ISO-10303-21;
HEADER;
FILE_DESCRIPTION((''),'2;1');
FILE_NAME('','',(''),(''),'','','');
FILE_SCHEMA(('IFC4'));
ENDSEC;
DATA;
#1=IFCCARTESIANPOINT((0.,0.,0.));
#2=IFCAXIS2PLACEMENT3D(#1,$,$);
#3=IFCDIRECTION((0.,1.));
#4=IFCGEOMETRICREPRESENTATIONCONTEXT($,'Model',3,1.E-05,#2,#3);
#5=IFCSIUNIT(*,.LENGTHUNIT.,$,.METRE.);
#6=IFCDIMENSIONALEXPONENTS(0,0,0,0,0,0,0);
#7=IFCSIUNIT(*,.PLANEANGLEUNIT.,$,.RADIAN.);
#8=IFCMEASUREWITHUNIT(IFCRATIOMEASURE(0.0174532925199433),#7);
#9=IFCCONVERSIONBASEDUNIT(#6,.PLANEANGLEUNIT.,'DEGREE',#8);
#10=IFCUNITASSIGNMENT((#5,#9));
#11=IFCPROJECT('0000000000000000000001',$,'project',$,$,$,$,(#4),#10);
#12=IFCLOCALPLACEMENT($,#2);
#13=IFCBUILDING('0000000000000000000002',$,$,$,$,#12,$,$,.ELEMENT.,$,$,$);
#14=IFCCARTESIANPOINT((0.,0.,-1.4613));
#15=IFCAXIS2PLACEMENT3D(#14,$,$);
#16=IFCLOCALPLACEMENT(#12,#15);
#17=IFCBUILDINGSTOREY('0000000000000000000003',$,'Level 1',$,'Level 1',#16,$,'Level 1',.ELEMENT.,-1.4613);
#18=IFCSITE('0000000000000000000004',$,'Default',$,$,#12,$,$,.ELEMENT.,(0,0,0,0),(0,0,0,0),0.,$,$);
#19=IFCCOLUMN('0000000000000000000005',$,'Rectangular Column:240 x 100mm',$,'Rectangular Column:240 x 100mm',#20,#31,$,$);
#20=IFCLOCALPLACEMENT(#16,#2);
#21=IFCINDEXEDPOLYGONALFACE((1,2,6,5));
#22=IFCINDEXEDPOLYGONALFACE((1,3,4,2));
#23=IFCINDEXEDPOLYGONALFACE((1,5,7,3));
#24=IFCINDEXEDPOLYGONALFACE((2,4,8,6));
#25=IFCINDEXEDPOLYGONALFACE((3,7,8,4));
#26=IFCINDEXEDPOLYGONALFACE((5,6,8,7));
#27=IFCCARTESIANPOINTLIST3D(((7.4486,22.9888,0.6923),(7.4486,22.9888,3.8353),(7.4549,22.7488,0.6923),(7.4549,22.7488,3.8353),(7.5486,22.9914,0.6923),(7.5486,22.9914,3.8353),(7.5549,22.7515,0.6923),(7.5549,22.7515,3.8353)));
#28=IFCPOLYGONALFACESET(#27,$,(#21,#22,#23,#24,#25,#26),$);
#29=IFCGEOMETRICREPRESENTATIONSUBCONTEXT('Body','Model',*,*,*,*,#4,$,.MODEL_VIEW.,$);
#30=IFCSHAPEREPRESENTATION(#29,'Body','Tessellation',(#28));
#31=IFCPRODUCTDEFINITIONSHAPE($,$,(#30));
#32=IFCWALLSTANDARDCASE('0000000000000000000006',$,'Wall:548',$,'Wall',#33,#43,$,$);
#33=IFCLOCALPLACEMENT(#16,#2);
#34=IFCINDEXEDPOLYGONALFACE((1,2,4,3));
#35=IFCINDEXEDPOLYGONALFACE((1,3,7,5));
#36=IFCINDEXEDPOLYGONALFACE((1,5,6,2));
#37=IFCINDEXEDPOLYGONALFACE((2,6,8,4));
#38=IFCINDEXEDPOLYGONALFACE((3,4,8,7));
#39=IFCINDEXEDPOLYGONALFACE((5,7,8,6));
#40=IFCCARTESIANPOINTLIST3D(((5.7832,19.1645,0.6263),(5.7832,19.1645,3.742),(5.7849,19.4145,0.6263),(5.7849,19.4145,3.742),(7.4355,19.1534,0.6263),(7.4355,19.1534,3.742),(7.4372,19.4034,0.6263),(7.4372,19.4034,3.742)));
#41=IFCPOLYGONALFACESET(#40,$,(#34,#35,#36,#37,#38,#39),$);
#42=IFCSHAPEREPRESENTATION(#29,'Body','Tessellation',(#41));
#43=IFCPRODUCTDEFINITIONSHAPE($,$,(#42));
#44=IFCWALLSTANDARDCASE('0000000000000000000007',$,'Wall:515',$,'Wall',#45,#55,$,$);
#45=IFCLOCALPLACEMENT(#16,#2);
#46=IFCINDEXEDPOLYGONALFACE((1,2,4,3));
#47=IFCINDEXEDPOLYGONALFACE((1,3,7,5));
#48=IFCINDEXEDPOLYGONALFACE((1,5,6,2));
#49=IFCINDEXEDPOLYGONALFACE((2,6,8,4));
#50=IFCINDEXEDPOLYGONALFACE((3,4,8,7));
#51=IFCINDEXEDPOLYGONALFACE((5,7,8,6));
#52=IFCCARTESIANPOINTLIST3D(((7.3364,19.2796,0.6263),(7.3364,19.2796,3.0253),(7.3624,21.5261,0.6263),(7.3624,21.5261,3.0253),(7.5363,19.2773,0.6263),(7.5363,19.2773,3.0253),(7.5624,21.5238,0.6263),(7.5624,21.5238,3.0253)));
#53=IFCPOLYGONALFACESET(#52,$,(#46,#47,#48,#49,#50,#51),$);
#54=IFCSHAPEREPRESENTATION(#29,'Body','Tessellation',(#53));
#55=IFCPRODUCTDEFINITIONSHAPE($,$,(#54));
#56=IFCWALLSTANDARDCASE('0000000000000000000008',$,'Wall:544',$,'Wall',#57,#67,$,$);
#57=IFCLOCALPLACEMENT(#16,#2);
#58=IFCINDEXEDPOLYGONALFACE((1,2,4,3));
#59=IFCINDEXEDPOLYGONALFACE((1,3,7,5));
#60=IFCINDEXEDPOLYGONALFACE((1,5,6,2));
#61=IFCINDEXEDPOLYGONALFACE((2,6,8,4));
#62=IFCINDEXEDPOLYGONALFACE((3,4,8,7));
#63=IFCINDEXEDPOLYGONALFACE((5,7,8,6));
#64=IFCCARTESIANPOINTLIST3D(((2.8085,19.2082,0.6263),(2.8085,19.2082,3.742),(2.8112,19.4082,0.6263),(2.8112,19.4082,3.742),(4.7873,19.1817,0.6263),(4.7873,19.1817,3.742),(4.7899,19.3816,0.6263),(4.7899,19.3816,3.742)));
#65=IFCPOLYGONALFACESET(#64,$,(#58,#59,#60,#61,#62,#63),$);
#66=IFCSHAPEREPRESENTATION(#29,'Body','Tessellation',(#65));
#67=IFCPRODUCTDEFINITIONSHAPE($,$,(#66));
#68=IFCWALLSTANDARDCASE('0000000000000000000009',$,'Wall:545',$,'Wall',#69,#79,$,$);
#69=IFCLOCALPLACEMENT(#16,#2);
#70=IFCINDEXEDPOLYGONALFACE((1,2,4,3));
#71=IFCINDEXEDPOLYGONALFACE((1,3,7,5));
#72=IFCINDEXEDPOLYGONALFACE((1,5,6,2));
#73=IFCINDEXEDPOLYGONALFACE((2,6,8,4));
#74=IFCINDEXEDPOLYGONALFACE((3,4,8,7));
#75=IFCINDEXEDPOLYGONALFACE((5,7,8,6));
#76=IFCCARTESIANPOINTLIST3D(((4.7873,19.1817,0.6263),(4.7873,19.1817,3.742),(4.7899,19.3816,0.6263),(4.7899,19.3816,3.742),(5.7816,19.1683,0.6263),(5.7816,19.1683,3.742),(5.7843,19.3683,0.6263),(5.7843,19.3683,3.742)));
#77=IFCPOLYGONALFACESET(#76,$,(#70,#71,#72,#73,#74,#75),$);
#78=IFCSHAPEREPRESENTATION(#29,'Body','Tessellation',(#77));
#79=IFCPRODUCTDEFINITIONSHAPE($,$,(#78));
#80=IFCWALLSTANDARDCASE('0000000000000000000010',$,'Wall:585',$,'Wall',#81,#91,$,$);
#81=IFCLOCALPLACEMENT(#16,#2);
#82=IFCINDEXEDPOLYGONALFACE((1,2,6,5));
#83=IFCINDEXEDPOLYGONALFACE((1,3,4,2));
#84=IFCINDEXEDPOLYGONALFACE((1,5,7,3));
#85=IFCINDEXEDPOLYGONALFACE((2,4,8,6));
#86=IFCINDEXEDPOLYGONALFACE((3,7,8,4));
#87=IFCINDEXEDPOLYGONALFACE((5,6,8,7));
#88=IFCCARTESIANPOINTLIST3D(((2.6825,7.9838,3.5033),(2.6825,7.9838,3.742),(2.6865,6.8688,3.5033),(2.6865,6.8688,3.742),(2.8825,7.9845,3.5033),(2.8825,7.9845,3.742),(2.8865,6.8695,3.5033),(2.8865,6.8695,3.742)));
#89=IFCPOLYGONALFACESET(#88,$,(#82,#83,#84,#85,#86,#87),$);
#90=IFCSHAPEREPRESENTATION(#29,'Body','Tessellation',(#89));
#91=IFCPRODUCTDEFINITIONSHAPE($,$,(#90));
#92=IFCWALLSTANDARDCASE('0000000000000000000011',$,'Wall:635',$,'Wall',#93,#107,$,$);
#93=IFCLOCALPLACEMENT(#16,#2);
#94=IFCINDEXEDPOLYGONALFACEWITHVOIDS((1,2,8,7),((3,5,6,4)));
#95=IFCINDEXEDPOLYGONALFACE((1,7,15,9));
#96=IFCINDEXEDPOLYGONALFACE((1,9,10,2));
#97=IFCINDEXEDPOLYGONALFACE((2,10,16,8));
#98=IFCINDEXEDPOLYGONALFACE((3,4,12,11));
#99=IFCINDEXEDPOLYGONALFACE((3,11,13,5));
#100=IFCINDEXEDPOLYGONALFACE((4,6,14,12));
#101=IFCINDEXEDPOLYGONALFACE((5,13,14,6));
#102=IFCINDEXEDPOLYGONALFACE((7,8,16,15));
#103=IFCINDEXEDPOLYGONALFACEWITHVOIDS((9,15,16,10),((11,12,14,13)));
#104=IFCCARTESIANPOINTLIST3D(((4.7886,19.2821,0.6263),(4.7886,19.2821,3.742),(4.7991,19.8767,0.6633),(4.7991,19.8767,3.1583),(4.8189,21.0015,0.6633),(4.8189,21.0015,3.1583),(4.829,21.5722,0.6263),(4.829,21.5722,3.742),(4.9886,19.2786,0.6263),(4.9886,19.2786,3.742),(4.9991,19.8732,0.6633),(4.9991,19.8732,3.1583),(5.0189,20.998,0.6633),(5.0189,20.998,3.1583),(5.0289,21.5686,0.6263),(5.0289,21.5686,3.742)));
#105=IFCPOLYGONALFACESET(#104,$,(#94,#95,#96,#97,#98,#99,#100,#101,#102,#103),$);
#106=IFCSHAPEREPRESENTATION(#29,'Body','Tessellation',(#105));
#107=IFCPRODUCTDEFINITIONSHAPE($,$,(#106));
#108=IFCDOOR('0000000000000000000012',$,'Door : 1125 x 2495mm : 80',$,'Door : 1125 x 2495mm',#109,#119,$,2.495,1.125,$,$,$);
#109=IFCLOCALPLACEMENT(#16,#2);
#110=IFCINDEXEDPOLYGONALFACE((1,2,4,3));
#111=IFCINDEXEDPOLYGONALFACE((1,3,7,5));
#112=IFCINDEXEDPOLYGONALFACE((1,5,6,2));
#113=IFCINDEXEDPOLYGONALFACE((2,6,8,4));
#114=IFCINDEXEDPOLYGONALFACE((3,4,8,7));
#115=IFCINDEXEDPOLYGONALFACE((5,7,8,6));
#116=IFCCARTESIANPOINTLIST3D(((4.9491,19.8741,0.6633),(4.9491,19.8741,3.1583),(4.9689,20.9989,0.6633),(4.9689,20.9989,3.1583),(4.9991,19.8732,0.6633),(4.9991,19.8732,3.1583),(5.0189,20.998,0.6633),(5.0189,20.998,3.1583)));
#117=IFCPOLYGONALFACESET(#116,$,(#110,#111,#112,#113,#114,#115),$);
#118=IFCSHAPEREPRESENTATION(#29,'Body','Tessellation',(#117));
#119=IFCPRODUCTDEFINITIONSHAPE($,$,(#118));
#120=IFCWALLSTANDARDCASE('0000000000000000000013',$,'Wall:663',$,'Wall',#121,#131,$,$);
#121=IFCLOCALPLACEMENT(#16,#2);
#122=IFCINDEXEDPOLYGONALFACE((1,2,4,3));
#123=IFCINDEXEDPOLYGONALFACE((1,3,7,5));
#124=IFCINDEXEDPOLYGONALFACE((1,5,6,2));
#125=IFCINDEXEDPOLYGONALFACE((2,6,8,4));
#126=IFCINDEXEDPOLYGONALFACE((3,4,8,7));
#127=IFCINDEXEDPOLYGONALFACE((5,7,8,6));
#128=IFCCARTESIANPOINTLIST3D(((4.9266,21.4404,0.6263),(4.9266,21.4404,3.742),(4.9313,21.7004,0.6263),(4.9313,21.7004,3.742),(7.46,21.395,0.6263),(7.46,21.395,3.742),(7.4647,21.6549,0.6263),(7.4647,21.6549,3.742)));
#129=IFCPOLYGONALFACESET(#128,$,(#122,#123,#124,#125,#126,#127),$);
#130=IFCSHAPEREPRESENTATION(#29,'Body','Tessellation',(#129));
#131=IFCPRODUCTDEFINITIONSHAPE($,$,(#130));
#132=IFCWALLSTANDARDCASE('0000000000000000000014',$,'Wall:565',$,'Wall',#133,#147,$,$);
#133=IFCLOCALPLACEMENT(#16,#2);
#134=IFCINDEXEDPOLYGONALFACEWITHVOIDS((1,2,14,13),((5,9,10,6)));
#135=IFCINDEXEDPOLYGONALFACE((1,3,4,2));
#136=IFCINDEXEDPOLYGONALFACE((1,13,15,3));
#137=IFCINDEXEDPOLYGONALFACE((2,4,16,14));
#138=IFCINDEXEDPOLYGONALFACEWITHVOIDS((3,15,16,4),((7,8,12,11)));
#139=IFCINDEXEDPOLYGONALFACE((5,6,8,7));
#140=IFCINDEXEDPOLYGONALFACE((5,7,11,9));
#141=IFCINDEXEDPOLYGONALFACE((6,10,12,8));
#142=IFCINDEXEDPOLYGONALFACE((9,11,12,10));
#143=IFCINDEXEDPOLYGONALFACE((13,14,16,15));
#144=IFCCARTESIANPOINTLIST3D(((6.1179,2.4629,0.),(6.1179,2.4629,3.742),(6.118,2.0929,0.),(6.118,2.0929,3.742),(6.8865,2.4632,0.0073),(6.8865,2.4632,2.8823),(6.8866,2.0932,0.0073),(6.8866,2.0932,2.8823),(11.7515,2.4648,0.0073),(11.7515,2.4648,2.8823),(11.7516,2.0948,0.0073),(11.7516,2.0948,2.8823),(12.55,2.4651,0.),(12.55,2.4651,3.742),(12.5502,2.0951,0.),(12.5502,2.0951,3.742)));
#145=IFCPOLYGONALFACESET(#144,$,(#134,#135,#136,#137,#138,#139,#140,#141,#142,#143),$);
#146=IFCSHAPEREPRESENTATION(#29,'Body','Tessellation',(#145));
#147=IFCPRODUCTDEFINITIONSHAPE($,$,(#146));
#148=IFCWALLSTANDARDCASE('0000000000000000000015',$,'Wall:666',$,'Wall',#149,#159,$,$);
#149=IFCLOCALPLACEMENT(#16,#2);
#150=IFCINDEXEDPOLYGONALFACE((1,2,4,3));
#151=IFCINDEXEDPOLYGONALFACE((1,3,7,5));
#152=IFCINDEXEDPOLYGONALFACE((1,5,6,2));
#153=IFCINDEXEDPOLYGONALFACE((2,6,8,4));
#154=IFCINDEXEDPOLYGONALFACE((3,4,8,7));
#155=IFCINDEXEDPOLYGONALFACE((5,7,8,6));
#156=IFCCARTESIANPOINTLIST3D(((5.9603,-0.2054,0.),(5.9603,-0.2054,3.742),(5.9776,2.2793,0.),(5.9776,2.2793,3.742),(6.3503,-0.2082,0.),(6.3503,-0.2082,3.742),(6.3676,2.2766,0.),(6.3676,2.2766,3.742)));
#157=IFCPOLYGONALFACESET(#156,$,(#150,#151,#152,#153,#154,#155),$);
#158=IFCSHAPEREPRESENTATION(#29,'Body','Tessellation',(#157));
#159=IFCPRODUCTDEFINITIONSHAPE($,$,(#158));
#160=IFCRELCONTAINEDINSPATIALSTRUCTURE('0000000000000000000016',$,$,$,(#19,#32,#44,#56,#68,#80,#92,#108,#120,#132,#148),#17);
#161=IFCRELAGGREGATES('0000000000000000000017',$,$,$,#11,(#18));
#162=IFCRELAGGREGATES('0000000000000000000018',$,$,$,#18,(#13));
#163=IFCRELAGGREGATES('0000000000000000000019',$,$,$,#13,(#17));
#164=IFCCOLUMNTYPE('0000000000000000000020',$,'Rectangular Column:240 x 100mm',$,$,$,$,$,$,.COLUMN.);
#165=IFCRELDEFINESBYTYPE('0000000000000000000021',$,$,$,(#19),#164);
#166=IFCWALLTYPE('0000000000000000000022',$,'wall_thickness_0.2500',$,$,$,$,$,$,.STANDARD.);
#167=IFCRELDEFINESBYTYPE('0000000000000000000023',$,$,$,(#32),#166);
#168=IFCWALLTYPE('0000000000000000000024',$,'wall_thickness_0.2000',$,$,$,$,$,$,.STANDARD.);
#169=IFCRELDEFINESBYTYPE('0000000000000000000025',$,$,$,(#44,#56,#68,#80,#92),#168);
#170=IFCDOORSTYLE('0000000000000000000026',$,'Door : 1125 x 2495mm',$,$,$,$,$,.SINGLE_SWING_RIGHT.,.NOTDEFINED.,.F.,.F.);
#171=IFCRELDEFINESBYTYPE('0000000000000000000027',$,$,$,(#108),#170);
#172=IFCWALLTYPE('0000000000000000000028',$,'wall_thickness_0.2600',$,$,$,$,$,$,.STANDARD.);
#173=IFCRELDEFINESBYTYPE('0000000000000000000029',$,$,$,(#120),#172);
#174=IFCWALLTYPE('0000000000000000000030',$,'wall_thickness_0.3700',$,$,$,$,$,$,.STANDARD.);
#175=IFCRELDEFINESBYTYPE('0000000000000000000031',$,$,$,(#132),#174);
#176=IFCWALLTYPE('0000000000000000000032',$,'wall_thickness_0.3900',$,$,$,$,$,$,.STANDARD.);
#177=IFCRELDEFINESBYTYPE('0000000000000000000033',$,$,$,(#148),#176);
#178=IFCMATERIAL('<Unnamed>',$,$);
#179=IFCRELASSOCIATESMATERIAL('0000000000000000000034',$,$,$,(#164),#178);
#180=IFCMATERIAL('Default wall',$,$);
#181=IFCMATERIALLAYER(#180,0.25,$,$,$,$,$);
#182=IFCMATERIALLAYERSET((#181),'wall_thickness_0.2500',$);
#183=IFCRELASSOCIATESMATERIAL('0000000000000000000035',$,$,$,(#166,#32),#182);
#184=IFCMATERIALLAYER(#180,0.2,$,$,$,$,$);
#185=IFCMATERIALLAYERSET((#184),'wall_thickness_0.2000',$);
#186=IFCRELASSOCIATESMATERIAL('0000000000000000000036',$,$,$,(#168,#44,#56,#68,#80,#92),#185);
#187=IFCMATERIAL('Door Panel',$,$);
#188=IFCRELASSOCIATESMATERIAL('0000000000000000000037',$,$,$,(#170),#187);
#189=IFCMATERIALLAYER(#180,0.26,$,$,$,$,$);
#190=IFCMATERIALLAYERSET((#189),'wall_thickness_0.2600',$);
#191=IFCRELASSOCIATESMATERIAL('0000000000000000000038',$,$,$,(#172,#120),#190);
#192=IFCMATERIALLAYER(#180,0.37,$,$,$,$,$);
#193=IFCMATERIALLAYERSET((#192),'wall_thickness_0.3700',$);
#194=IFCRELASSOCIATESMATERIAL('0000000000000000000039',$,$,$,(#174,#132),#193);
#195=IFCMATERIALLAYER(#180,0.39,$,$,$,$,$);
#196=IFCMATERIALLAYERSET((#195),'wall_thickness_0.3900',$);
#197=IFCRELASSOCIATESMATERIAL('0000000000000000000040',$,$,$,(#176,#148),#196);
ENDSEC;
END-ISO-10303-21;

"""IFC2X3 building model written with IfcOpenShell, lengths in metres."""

from ifc_helpers import new_model, entity, si_unit, converted_unit, direction, frame, frame_2d, origin, origin_2d_with_axis, place, context, subcontext, project, spatial, polyline, rectangle, outline, extrude, source, transform, mapped, material, layer, layer_set, layer_usage, type_object, type_shapes, element, fill, save


model = new_model("IFC2X3")

# Units and contexts
model_context = context("Model", 3, precision=1e-05, world=origin(), true_north=direction((0.0, 1.0)))
body_context = subcontext(model_context, "Body", "Model", "MODEL_VIEW")
ifc_project = project(units=[si_unit("LENGTHUNIT", "METRE"), converted_unit("PLANEANGLEUNIT", "DEGREE", entity("IfcRatioMeasure", 0.0174532925199433), si_unit("PLANEANGLEUNIT", "RADIAN"), dimensions=[0, 0, 0, 0, 0, 0, 0])], contexts=[model_context])

# Site, building, storey
placement_1 = place(None, origin())
site = spatial("IfcSite", under=ifc_project, at=placement_1, Name="Default", CompositionType="ELEMENT", RefLatitude=(0, 0, 0, 0), RefLongitude=(0, 0, 0, 0), RefElevation=0.0)
building = spatial("IfcBuilding", under=site, at=placement_1, CompositionType="ELEMENT")
storey_placement = place(placement_1, frame((0.0, 0.0, -1.4613)))
storey = spatial("IfcBuildingStorey", under=building, at=storey_placement, Name="Level 1", ObjectType="Level 1", LongName="Level 1", CompositionType="ELEMENT", Elevation=-1.4613)

# Column
ifc_material_1 = material(Name="<Unnamed>")
column_type = type_object("IfcColumnType", Name="Rectangular Column:240 x 100mm", PredefinedType="COLUMN", material=ifc_material_1)
shared_shape_1 = source(origin(), body_context, "Body", "SweptSolid", [
    extrude(rectangle(XDim=0.24, YDim=0.1, at=origin_2d_with_axis()), frame((0.0, 0.0, 0.0), z_axis=(0.0, 0.0, 1.0), x_axis=(0.0, -1.0, 0.0)), (0.0, 0.0, 1.0), 3.143),
])
type_shapes(column_type, [shared_shape_1])
column_placement = place(placement_1, frame((7.5018, 22.8701, -0.769), z_axis=(0.0, 0.0, 1.0), x_axis=(0.99966, 0.026087, 0.0)))
element("IfcColumn", 1, at=column_placement, inside=storey, type_object=column_type, Name="Rectangular Column:240 x 100mm", ObjectType="Rectangular Column:240 x 100mm", context=body_context, shape_type="MappedRepresentation", body=[
    mapped(shared_shape_1, transform((0.0, 0.0, 0.0), scale=1.0)),
])

# Walls
ifc_material_2 = material(Name="Default wall")
ifc_layer_1 = layer(ifc_material_2, 0.25)
ifc_layer_set_1 = layer_set([ifc_layer_1], Name="wall_thickness_0.2500")
ifc_layer_usage_1 = layer_usage(ifc_layer_set_1, "AXIS2", "POSITIVE", -0.125)
wall_type_1 = type_object("IfcWallType", Name="wall_thickness_0.2500", PredefinedType="STANDARD", material=ifc_layer_set_1)
placement_2 = place(placement_1, frame((0.0, 0.0, -0.835)))
wall_1_placement = place(placement_2, frame((5.7841, 19.2895, 0.0), z_axis=(0.0, 0.0, 1.0), x_axis=(0.999978, -0.006702, 0.0)))
element("IfcWallStandardCase", 2, at=wall_1_placement, inside=storey, type_object=wall_type_1, material=ifc_layer_usage_1, Name="Wall:548", ObjectType="Wall", context=body_context, shape_type="SweptSolid", body=[
    extrude(outline(polyline([(1.6523, -0.125), (1.6523, 0.125), (0.0, 0.125), (0.0, -0.125), (1.6523, -0.125)])), origin(), (0.0, 0.0, 1.0), 3.1157),
])
ifc_layer_2 = layer(ifc_material_2, 0.2)
ifc_layer_set_2 = layer_set([ifc_layer_2], Name="wall_thickness_0.2000")
ifc_layer_usage_2 = layer_usage(ifc_layer_set_2, "AXIS2", "POSITIVE", -0.1)
wall_type_2 = type_object("IfcWallType", Name="wall_thickness_0.2000", PredefinedType="STANDARD", material=ifc_layer_set_2)
placement_3 = place(placement_1, frame((0.0, 0.0, -0.835)))
wall_2_placement = place(placement_3, frame((7.4624, 21.5249, 0.0), z_axis=(0.0, 0.0, 1.0), x_axis=(-0.011587, -0.999933, 0.0)))
element("IfcWallStandardCase", 3, at=wall_2_placement, inside=storey, type_object=wall_type_2, material=ifc_layer_usage_2, Name="Wall:515", ObjectType="Wall", context=body_context, shape_type="SweptSolid", body=[
    extrude(outline(polyline([(2.2467, -0.1), (2.2467, 0.1), (0.0, 0.1), (0.0, -0.1), (2.2467, -0.1)])), origin(), (0.0, 0.0, 1.0), 2.399),
])
placement_4 = place(placement_1, frame((0.0, 0.0, -0.835)))
wall_3_placement = place(placement_4, frame((2.8098, 19.3082, 0.0), z_axis=(0.0, 0.0, 1.0), x_axis=(0.99991, -0.013422, 0.0)))
element("IfcWallStandardCase", 4, at=wall_3_placement, inside=storey, type_object=wall_type_2, material=ifc_layer_usage_2, Name="Wall:544", ObjectType="Wall", context=body_context, shape_type="SweptSolid", body=[
    extrude(outline(polyline([(1.979, -0.1), (1.979, 0.1), (0.0, 0.1), (0.0, -0.1), (1.979, -0.1)])), origin(), (0.0, 0.0, 1.0), 3.1157),
])
placement_5 = place(placement_1, frame((0.0, 0.0, -0.835)))
wall_4_placement = place(placement_5, frame((4.7886, 19.2817, 0.0), z_axis=(0.0, 0.0, 1.0), x_axis=(0.99991, -0.013422, 0.0)))
element("IfcWallStandardCase", 5, at=wall_4_placement, inside=storey, type_object=wall_type_2, material=ifc_layer_usage_2, Name="Wall:545", ObjectType="Wall", context=body_context, shape_type="SweptSolid", body=[
    extrude(outline(polyline([(0.9944, -0.1), (0.9944, 0.1), (0.0, 0.1), (0.0, -0.1), (0.9944, -0.1)])), origin(), (0.0, 0.0, 1.0), 3.1157),
])
placement_6 = place(placement_1, frame((0.0, 0.0, 2.042)))
wall_5_placement = place(placement_6, frame((2.7865, 6.8691, 0.0), z_axis=(0.0, 0.0, 1.0), x_axis=(-0.003571, 0.999994, 0.0)))
element("IfcWallStandardCase", 6, at=wall_5_placement, inside=storey, type_object=wall_type_2, material=ifc_layer_usage_2, Name="Wall:585", ObjectType="Wall", context=body_context, shape_type="SweptSolid", body=[
    extrude(outline(polyline([(1.115, -0.1), (1.115, 0.1), (0.0, 0.1), (0.0, -0.1), (1.115, -0.1)])), origin(), (0.0, 0.0, 1.0), 0.2387),
])

# Wall, opening, door
placement_7 = place(placement_1, frame((0.0, 0.0, -0.835)))
wall_6_placement = place(placement_7, frame((4.9289, 21.5704, 0.0), z_axis=(0.0, 0.0, 1.0), x_axis=(-0.017619, -0.999845, 0.0)))
wall_6 = element("IfcWallStandardCase", 7, at=wall_6_placement, inside=storey, type_object=wall_type_2, material=ifc_layer_usage_2, Name="Wall:635", ObjectType="Wall", context=body_context, shape_type="SweptSolid", body=[
    extrude(outline(polyline([(2.2905, -0.1), (2.2905, 0.1), (0.0, 0.1), (0.0, -0.1), (2.2905, -0.1)])), origin(), (0.0, 0.0, 1.0), 3.1157),
])
opening_1_placement = place(wall_6_placement, frame((0.5707, -0.1, 0.037)))
opening_1 = element("IfcOpeningElement", 8, at=opening_1_placement, cuts=wall_6, ObjectType="Opening", context=body_context, shape_type="SweptSolid", body=[
    extrude(rectangle(XDim=1.125, YDim=2.495, at=frame_2d((1.2475, 0.5625), x_axis=(0.0, 1.0))), frame((0.0, 0.0, 0.0), z_axis=(0.0, 1.0, 0.0), x_axis=(0.0, 0.0, 1.0)), (0.0, 0.0, 1.0), 0.2),
])
ifc_material_3 = material(Name="Door Panel")
door_style_1 = type_object("IfcDoorStyle", Name="Door : 1125 x 2495mm", ConstructionType="NOTDEFINED", OperationType="SINGLE_SWING_RIGHT", ParameterTakesPrecedence=False, Sizeable=False, material=ifc_material_3)
shared_shape_2 = source(origin(), body_context, "Body", "SweptSolid", [
    extrude(rectangle(XDim=0.05, YDim=1.125, at=origin_2d_with_axis()), frame((0.5625, 0.175, 0.0), z_axis=(0.0, 0.0, 1.0), x_axis=(0.0, 1.0, 0.0)), (0.0, 0.0, 1.0), 2.495),
])
type_shapes(door_style_1, [shared_shape_2])
door_1_placement = place(opening_1_placement, origin())
door_1 = element("IfcDoor", 9, at=door_1_placement, inside=storey, type_object=door_style_1, Name="Door : 1125 x 2495mm : 80", ObjectType="Door : 1125 x 2495mm", OverallHeight=2.495, OverallWidth=1.125, context=body_context, shape_type="MappedRepresentation", body=[
    mapped(shared_shape_2, transform((0.0, 0.0, 0.0), scale=1.0)),
])
fill(opening_1, door_1)

# Wall
ifc_layer_3 = layer(ifc_material_2, 0.26)
ifc_layer_set_3 = layer_set([ifc_layer_3], Name="wall_thickness_0.2600")
ifc_layer_usage_3 = layer_usage(ifc_layer_set_3, "AXIS2", "POSITIVE", -0.13)
wall_type_3 = type_object("IfcWallType", Name="wall_thickness_0.2600", PredefinedType="STANDARD", material=ifc_layer_set_3)
placement_8 = place(placement_1, frame((0.0, 0.0, -0.835)))
wall_7_placement = place(placement_8, frame((4.9289, 21.5704, 0.0), z_axis=(0.0, 0.0, 1.0), x_axis=(0.999839, -0.017946, 0.0)))
element("IfcWallStandardCase", 10, at=wall_7_placement, inside=storey, type_object=wall_type_3, material=ifc_layer_usage_3, Name="Wall:663", ObjectType="Wall", context=body_context, shape_type="SweptSolid", body=[
    extrude(outline(polyline([(2.5338, -0.13), (2.5338, 0.13), (0.0, 0.13), (0.0, -0.13), (2.5338, -0.13)])), origin(), (0.0, 0.0, 1.0), 3.1157),
])

# Wall, opening
ifc_layer_4 = layer(ifc_material_2, 0.37)
ifc_layer_set_4 = layer_set([ifc_layer_4], Name="wall_thickness_0.3700")
ifc_layer_usage_4 = layer_usage(ifc_layer_set_4, "AXIS2", "POSITIVE", -0.185)
wall_type_4 = type_object("IfcWallType", Name="wall_thickness_0.3700", PredefinedType="STANDARD", material=ifc_layer_set_4)
wall_8_placement = place(storey_placement, frame((6.1179, 2.2779, 0.0), z_axis=(0.0, 0.0, 1.0), x_axis=(1.0, 0.000342, 0.0)))
wall_8 = element("IfcWallStandardCase", 11, at=wall_8_placement, inside=storey, type_object=wall_type_4, material=ifc_layer_usage_4, Name="Wall:565", ObjectType="Wall", context=body_context, shape_type="SweptSolid", body=[
    extrude(outline(polyline([(6.4322, -0.185), (6.4322, 0.185), (0.0, 0.185), (0.0, -0.185), (6.4322, -0.185)])), origin(), (0.0, 0.0, 1.0), 3.742),
])
opening_2_placement = place(wall_8_placement, frame((0.7686, -0.185, 0.0073)))
element("IfcOpeningElement", 12, at=opening_2_placement, cuts=wall_8, ObjectType="Opening", context=body_context, shape_type="SweptSolid", body=[
    extrude(rectangle(XDim=4.865, YDim=2.875, at=frame_2d((1.4375, 2.4325), x_axis=(0.0, 1.0))), frame((0.0, 0.0, 0.0), z_axis=(0.0, 1.0, 0.0), x_axis=(0.0, 0.0, 1.0)), (0.0, 0.0, 1.0), 0.37),
])

# Wall
ifc_layer_5 = layer(ifc_material_2, 0.39)
ifc_layer_set_5 = layer_set([ifc_layer_5], Name="wall_thickness_0.3900")
ifc_layer_usage_5 = layer_usage(ifc_layer_set_5, "AXIS2", "POSITIVE", -0.195)
wall_type_5 = type_object("IfcWallType", Name="wall_thickness_0.3900", PredefinedType="STANDARD", material=ifc_layer_set_5)
wall_9_placement = place(storey_placement, frame((6.1726, 2.2779, 0.0), z_axis=(0.0, 0.0, 1.0), x_axis=(-0.006987, -0.999976, 0.0)))
element("IfcWallStandardCase", 13, at=wall_9_placement, inside=storey, type_object=wall_type_5, material=ifc_layer_usage_5, Name="Wall:666", ObjectType="Wall", context=body_context, shape_type="SweptSolid", body=[
    extrude(outline(polyline([(2.4848, -0.195), (2.4848, 0.195), (0.0, 0.195), (0.0, -0.195), (2.4848, -0.195)])), origin(), (0.0, 0.0, 1.0), 3.742),
])

save(model, "model.ifc")
